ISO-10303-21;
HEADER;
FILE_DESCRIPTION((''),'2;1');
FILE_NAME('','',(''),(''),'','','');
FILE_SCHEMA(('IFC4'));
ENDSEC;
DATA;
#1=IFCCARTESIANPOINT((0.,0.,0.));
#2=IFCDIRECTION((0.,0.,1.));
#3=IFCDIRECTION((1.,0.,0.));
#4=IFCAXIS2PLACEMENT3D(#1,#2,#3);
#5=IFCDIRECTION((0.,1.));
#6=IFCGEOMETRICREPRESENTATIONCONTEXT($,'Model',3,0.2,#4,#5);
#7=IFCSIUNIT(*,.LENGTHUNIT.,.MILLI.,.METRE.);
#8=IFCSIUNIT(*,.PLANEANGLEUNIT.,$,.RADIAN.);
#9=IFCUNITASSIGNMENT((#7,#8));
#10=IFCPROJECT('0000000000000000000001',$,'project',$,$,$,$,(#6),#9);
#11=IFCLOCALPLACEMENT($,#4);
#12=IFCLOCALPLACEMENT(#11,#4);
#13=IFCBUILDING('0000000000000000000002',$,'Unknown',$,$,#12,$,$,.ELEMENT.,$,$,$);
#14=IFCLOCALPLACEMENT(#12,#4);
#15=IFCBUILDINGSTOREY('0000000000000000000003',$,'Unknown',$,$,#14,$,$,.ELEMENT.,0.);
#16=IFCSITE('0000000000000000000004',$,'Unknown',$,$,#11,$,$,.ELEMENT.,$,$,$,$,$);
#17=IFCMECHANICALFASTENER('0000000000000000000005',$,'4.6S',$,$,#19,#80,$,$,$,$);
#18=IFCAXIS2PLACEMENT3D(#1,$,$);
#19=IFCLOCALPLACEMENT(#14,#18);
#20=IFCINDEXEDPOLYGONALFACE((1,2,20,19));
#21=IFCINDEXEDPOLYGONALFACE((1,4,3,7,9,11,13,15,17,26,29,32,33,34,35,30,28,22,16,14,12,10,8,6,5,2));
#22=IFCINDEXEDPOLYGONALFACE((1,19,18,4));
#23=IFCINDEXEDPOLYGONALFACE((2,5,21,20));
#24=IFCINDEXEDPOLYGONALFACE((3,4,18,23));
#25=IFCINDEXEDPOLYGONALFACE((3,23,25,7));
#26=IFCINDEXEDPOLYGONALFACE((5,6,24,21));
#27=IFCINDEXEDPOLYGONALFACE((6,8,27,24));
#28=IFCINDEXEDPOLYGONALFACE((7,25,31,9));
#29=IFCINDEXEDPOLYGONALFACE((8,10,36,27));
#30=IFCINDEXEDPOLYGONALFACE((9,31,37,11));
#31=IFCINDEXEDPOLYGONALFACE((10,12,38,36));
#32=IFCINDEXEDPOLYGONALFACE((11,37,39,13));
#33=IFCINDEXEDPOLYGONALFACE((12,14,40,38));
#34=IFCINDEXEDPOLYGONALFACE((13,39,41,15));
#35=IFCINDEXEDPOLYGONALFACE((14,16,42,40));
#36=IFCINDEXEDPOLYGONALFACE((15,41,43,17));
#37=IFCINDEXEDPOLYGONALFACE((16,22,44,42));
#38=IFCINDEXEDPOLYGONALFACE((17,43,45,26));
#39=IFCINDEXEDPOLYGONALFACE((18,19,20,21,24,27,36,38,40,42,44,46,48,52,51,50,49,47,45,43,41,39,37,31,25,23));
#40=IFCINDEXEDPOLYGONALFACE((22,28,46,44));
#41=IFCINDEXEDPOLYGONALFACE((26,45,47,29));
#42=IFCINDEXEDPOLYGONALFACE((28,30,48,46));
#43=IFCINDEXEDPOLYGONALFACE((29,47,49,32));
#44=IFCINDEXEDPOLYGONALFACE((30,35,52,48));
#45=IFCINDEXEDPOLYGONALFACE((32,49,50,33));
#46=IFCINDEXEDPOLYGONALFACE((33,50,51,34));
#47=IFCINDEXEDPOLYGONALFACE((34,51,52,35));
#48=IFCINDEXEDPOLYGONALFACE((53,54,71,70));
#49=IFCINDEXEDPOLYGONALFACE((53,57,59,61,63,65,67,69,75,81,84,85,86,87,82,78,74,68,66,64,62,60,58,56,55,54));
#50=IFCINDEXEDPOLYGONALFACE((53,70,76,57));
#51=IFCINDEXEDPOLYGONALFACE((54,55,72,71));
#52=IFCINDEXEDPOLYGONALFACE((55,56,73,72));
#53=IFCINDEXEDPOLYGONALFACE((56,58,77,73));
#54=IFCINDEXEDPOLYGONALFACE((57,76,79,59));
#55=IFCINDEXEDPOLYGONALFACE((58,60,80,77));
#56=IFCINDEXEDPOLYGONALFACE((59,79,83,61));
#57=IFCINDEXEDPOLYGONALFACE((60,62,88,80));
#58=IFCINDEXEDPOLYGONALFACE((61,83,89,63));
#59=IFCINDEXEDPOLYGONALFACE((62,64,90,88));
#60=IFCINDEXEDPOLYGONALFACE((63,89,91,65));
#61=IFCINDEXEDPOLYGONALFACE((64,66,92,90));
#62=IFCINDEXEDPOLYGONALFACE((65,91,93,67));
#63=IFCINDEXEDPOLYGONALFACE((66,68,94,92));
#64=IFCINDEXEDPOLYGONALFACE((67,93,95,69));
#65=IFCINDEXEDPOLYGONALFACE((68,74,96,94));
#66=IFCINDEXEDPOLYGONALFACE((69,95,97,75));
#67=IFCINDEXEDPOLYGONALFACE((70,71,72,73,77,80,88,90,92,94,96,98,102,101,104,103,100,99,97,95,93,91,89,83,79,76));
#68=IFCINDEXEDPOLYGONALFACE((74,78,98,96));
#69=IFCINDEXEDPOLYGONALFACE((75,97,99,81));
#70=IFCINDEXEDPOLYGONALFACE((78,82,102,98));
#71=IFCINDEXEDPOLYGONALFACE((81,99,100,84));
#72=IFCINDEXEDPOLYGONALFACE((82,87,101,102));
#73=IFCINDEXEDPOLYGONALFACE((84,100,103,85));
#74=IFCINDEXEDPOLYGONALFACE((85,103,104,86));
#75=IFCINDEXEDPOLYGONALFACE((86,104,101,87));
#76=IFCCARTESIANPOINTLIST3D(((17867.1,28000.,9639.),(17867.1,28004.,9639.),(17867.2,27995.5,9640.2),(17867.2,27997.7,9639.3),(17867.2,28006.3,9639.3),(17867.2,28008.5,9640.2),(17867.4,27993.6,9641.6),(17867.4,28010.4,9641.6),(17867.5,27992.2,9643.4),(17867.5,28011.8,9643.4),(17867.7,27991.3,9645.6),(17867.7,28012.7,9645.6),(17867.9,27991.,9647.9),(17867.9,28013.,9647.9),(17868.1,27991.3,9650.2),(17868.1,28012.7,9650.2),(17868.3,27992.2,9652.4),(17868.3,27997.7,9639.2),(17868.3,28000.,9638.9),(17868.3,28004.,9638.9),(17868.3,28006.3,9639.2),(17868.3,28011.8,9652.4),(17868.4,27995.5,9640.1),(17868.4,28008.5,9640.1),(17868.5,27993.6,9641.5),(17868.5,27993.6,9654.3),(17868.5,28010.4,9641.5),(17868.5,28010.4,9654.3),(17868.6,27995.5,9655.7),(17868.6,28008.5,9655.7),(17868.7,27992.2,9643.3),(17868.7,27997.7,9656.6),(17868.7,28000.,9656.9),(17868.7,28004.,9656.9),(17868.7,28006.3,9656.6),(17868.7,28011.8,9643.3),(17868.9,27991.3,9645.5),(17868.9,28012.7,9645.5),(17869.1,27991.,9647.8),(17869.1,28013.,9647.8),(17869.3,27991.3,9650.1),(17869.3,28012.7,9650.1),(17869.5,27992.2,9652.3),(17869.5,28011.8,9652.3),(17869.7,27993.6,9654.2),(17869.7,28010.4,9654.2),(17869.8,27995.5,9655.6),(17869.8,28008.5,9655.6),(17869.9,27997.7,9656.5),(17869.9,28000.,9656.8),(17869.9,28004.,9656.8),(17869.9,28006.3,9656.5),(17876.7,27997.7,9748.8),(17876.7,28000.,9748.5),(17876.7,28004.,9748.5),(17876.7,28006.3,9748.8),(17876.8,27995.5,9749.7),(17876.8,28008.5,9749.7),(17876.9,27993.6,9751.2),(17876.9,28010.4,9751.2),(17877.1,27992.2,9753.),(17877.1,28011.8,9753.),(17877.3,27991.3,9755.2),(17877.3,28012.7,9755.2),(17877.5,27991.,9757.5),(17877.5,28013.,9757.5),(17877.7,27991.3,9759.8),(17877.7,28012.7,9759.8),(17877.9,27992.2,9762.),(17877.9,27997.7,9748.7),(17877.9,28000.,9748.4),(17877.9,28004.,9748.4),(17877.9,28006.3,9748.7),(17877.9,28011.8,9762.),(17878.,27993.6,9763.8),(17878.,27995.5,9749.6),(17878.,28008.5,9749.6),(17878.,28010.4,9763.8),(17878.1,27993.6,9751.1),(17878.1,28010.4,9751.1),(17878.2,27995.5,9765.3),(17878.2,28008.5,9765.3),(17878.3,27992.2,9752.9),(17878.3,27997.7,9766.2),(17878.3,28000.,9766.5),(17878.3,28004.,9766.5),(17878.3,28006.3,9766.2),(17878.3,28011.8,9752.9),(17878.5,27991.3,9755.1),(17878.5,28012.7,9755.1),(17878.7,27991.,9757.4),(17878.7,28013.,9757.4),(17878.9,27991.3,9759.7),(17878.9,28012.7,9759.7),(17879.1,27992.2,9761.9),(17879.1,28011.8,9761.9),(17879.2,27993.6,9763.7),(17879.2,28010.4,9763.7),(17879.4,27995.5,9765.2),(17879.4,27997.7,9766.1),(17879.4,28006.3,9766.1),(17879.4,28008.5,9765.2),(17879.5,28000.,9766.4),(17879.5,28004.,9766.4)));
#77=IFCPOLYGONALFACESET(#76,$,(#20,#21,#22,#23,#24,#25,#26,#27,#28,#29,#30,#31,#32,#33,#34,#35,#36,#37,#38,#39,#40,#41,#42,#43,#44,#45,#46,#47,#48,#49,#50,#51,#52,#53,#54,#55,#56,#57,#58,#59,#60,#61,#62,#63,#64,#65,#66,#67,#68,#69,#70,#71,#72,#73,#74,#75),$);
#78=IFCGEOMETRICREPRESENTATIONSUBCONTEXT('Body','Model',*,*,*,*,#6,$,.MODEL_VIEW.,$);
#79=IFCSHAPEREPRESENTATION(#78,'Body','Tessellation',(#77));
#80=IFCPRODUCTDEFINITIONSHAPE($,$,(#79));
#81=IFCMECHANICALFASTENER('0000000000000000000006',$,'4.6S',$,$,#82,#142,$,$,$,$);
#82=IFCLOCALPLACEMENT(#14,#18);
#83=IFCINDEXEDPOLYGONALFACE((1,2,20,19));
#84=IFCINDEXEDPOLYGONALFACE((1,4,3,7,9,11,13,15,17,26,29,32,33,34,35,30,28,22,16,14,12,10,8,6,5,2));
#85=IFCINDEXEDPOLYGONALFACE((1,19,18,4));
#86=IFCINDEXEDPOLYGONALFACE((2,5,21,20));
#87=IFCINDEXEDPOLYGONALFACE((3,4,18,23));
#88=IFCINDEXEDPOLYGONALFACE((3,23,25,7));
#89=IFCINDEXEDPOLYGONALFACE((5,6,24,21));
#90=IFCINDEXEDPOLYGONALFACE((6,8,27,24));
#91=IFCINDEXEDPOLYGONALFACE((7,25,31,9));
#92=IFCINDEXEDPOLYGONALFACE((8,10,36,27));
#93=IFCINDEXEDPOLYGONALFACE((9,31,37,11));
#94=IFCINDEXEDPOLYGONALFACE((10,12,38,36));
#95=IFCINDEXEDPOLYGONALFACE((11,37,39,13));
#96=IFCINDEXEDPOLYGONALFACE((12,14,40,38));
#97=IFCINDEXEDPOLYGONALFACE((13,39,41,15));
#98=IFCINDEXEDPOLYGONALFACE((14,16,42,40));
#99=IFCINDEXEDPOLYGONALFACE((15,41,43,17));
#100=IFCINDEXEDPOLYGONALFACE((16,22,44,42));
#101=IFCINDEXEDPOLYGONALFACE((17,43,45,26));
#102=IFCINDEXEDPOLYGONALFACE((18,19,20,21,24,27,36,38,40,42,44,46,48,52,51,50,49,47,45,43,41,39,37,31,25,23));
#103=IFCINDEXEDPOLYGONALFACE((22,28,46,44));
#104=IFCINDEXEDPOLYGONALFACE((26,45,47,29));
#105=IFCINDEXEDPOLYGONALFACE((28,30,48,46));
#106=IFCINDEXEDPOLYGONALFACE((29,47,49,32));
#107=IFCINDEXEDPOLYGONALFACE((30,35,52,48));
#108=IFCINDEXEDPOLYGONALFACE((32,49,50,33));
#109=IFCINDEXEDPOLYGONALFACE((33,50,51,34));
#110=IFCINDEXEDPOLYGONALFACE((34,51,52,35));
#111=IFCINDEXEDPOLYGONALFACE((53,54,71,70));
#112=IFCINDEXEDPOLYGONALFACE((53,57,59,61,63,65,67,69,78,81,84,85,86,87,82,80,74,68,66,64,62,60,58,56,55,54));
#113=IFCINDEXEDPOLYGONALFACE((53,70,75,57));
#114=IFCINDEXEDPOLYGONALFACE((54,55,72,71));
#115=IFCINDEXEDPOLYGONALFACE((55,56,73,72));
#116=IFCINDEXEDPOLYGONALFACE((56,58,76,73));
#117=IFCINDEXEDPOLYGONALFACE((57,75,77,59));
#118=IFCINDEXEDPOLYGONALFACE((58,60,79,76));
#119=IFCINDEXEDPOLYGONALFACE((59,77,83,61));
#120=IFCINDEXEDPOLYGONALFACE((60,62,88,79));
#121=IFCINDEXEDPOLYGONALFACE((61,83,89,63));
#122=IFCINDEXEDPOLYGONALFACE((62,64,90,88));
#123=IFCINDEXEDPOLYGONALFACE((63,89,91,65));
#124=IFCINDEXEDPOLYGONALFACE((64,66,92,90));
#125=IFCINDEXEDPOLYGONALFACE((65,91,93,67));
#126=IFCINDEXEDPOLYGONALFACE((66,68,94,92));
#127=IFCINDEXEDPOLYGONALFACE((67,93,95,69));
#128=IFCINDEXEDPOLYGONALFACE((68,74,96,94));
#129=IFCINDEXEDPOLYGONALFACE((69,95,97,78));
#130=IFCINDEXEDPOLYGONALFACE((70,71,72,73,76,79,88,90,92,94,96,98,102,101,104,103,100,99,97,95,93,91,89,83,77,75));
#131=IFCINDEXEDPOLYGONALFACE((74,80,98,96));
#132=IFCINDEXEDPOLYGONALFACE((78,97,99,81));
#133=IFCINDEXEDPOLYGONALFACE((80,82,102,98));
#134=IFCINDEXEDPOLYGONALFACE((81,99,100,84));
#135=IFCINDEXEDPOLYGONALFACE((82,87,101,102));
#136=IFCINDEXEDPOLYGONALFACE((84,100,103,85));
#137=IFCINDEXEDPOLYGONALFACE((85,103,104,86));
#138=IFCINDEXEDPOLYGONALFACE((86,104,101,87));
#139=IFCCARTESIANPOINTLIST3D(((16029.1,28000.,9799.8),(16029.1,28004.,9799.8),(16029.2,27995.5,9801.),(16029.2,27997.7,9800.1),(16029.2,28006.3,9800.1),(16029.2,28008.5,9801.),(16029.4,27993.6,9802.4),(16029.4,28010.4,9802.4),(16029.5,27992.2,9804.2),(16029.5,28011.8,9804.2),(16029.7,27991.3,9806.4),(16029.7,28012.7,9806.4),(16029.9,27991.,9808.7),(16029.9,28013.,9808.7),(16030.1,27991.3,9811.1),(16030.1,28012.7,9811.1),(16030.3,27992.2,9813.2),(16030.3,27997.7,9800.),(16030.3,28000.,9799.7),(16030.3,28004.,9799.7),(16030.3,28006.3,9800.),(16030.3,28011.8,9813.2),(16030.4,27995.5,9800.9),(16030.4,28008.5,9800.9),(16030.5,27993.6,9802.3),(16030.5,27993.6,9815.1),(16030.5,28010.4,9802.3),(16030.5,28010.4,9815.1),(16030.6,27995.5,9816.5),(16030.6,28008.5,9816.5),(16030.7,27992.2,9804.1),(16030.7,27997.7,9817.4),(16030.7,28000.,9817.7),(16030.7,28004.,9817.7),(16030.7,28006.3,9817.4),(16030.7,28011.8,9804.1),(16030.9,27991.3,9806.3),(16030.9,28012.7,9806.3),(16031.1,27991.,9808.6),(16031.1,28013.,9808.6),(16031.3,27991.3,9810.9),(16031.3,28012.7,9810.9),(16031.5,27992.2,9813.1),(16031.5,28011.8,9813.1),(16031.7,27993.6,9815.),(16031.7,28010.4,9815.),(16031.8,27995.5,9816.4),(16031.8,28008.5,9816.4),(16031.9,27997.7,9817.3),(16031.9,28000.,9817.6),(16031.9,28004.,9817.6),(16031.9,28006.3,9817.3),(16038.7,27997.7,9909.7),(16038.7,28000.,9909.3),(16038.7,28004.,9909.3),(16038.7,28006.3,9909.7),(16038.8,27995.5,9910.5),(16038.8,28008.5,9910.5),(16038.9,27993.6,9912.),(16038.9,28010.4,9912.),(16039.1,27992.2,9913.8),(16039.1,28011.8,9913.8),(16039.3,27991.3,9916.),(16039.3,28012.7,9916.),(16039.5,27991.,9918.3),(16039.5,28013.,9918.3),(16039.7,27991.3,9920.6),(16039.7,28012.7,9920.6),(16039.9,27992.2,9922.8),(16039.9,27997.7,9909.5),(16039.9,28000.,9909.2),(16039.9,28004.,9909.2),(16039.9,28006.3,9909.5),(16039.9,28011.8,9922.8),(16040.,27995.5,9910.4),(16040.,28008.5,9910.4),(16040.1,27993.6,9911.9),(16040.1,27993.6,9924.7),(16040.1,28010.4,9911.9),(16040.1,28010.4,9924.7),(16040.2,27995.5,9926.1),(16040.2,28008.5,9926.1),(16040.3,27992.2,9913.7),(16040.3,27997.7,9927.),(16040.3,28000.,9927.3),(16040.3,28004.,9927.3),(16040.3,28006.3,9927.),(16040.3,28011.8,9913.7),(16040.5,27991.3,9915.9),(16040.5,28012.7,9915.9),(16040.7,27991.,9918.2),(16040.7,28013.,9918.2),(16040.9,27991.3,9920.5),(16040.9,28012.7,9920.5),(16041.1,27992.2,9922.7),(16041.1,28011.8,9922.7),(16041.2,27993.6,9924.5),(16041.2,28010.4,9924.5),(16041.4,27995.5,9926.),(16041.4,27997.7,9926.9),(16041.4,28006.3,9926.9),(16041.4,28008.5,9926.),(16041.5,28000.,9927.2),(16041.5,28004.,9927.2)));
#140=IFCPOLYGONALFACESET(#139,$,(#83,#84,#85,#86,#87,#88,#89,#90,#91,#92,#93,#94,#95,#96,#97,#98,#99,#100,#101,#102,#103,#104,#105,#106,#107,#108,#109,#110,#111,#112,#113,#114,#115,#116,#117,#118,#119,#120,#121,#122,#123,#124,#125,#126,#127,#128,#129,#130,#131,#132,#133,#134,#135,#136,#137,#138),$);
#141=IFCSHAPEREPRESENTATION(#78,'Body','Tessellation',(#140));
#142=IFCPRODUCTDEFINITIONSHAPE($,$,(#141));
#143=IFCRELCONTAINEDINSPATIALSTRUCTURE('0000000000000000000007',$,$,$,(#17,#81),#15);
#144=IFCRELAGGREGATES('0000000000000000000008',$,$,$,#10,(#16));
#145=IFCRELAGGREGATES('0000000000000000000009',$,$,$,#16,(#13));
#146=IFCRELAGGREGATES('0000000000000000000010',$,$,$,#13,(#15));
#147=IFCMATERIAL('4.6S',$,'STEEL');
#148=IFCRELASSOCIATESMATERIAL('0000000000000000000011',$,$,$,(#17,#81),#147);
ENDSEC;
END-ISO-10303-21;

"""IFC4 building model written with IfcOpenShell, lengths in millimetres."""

from ifc_helpers import new_model, si_unit, direction, frame, origin_with_axes, place, context, subcontext, project, spatial, line, arc, indexed_curve, outline, extrude, source, transform, mapped, material, element, save


model = new_model("IFC4")

# Units and contexts
model_context = context("Model", 3, precision=0.2, world=origin_with_axes(), true_north=direction((0.0, 1.0)))
body_context = subcontext(model_context, "Body", "Model", "MODEL_VIEW")
ifc_project = project(units=[si_unit("LENGTHUNIT", "METRE", prefix="MILLI"), si_unit("PLANEANGLEUNIT", "RADIAN")], contexts=[model_context])

# Site, building, storey
site_placement = place(None, origin_with_axes())
site = spatial("IfcSite", under=ifc_project, at=site_placement, Name="Unknown", CompositionType="ELEMENT")
building_placement = place(site_placement, origin_with_axes())
building = spatial("IfcBuilding", under=site, at=building_placement, Name="Unknown", CompositionType="ELEMENT")
storey_placement = place(building_placement, origin_with_axes())
storey = spatial("IfcBuildingStorey", under=building, at=storey_placement, Name="Unknown", CompositionType="ELEMENT", Elevation=0.0)

# Mechanical fasteners
ifc_material_1 = material(Name="4.6S", Category="STEEL")
shared_shape_1 = source(origin_with_axes(), body_context, "Body", "SweptSolid", [
    extrude(outline(indexed_curve([(-2.0, 9.0), (2.0, 9.0), (2.0, 9.0), (8.4, 6.4), (11.0, 0.0), (8.4, -6.4), (2.0, -9.0), (-2.0, -9.0), (-2.8, -9.0), (-11.0, 0.0), (-8.4, 6.4)], segments=[line(1, 2, 3), arc(3, 4, 5), arc(5, 6, 7), line(7, 8), arc(8, 9, 10), arc(10, 11, 1)])), frame((0.0, 0.0, 0.6), z_axis=(0.0, 0.0, -1.0), x_axis=(0.0, 1.0, 0.0)), (0.0, 0.0, 1.0), 1.2),
])
mechanical_fastener_1_placement = place(storey_placement, frame((17868.5, 28002.0, 9647.9), z_axis=(-0.996195, 0.0, 0.08715), x_axis=(0.08715, 0.0, 0.996195)))
element("IfcMechanicalFastener", 1, at=mechanical_fastener_1_placement, inside=storey, material=ifc_material_1, Name="4.6S", context=body_context, shape_type="MappedRepresentation", body=[
    mapped(shared_shape_1, transform((0.0, 0.0, 0.0))),
    mapped(shared_shape_1, transform((110.0, 0.0, 0.0))),
])
shared_shape_2 = source(origin_with_axes(), body_context, "Body", "SweptSolid", [
    extrude(outline(indexed_curve([(-2.0, 9.0), (2.0, 9.0), (2.0, 9.0), (8.4, 6.4), (11.0, 0.0), (8.4, -6.4), (2.0, -9.0), (-2.0, -9.0), (-2.8, -9.0), (-11.0, 0.0), (-8.4, 6.4)], segments=[line(1, 2, 3), arc(3, 4, 5), arc(5, 6, 7), line(7, 8), arc(8, 9, 10), arc(10, 11, 1)])), frame((0.0, 0.0, 0.6), z_axis=(0.0, 0.0, -1.0), x_axis=(0.0, 1.0, 0.0)), (0.0, 0.0, 1.0), 1.2),
])
mechanical_fastener_2_placement = place(storey_placement, frame((16030.5, 28002.0, 9808.7), z_axis=(-0.996194, 0.0, 0.087163), x_axis=(0.087163, 0.0, 0.996194)))
element("IfcMechanicalFastener", 2, at=mechanical_fastener_2_placement, inside=storey, material=ifc_material_1, Name="4.6S", context=body_context, shape_type="MappedRepresentation", body=[
    mapped(shared_shape_2, transform((0.0, 0.0, 0.0))),
    mapped(shared_shape_2, transform((110.0, 0.0, 0.0))),
])

save(model, "model.ifc")
